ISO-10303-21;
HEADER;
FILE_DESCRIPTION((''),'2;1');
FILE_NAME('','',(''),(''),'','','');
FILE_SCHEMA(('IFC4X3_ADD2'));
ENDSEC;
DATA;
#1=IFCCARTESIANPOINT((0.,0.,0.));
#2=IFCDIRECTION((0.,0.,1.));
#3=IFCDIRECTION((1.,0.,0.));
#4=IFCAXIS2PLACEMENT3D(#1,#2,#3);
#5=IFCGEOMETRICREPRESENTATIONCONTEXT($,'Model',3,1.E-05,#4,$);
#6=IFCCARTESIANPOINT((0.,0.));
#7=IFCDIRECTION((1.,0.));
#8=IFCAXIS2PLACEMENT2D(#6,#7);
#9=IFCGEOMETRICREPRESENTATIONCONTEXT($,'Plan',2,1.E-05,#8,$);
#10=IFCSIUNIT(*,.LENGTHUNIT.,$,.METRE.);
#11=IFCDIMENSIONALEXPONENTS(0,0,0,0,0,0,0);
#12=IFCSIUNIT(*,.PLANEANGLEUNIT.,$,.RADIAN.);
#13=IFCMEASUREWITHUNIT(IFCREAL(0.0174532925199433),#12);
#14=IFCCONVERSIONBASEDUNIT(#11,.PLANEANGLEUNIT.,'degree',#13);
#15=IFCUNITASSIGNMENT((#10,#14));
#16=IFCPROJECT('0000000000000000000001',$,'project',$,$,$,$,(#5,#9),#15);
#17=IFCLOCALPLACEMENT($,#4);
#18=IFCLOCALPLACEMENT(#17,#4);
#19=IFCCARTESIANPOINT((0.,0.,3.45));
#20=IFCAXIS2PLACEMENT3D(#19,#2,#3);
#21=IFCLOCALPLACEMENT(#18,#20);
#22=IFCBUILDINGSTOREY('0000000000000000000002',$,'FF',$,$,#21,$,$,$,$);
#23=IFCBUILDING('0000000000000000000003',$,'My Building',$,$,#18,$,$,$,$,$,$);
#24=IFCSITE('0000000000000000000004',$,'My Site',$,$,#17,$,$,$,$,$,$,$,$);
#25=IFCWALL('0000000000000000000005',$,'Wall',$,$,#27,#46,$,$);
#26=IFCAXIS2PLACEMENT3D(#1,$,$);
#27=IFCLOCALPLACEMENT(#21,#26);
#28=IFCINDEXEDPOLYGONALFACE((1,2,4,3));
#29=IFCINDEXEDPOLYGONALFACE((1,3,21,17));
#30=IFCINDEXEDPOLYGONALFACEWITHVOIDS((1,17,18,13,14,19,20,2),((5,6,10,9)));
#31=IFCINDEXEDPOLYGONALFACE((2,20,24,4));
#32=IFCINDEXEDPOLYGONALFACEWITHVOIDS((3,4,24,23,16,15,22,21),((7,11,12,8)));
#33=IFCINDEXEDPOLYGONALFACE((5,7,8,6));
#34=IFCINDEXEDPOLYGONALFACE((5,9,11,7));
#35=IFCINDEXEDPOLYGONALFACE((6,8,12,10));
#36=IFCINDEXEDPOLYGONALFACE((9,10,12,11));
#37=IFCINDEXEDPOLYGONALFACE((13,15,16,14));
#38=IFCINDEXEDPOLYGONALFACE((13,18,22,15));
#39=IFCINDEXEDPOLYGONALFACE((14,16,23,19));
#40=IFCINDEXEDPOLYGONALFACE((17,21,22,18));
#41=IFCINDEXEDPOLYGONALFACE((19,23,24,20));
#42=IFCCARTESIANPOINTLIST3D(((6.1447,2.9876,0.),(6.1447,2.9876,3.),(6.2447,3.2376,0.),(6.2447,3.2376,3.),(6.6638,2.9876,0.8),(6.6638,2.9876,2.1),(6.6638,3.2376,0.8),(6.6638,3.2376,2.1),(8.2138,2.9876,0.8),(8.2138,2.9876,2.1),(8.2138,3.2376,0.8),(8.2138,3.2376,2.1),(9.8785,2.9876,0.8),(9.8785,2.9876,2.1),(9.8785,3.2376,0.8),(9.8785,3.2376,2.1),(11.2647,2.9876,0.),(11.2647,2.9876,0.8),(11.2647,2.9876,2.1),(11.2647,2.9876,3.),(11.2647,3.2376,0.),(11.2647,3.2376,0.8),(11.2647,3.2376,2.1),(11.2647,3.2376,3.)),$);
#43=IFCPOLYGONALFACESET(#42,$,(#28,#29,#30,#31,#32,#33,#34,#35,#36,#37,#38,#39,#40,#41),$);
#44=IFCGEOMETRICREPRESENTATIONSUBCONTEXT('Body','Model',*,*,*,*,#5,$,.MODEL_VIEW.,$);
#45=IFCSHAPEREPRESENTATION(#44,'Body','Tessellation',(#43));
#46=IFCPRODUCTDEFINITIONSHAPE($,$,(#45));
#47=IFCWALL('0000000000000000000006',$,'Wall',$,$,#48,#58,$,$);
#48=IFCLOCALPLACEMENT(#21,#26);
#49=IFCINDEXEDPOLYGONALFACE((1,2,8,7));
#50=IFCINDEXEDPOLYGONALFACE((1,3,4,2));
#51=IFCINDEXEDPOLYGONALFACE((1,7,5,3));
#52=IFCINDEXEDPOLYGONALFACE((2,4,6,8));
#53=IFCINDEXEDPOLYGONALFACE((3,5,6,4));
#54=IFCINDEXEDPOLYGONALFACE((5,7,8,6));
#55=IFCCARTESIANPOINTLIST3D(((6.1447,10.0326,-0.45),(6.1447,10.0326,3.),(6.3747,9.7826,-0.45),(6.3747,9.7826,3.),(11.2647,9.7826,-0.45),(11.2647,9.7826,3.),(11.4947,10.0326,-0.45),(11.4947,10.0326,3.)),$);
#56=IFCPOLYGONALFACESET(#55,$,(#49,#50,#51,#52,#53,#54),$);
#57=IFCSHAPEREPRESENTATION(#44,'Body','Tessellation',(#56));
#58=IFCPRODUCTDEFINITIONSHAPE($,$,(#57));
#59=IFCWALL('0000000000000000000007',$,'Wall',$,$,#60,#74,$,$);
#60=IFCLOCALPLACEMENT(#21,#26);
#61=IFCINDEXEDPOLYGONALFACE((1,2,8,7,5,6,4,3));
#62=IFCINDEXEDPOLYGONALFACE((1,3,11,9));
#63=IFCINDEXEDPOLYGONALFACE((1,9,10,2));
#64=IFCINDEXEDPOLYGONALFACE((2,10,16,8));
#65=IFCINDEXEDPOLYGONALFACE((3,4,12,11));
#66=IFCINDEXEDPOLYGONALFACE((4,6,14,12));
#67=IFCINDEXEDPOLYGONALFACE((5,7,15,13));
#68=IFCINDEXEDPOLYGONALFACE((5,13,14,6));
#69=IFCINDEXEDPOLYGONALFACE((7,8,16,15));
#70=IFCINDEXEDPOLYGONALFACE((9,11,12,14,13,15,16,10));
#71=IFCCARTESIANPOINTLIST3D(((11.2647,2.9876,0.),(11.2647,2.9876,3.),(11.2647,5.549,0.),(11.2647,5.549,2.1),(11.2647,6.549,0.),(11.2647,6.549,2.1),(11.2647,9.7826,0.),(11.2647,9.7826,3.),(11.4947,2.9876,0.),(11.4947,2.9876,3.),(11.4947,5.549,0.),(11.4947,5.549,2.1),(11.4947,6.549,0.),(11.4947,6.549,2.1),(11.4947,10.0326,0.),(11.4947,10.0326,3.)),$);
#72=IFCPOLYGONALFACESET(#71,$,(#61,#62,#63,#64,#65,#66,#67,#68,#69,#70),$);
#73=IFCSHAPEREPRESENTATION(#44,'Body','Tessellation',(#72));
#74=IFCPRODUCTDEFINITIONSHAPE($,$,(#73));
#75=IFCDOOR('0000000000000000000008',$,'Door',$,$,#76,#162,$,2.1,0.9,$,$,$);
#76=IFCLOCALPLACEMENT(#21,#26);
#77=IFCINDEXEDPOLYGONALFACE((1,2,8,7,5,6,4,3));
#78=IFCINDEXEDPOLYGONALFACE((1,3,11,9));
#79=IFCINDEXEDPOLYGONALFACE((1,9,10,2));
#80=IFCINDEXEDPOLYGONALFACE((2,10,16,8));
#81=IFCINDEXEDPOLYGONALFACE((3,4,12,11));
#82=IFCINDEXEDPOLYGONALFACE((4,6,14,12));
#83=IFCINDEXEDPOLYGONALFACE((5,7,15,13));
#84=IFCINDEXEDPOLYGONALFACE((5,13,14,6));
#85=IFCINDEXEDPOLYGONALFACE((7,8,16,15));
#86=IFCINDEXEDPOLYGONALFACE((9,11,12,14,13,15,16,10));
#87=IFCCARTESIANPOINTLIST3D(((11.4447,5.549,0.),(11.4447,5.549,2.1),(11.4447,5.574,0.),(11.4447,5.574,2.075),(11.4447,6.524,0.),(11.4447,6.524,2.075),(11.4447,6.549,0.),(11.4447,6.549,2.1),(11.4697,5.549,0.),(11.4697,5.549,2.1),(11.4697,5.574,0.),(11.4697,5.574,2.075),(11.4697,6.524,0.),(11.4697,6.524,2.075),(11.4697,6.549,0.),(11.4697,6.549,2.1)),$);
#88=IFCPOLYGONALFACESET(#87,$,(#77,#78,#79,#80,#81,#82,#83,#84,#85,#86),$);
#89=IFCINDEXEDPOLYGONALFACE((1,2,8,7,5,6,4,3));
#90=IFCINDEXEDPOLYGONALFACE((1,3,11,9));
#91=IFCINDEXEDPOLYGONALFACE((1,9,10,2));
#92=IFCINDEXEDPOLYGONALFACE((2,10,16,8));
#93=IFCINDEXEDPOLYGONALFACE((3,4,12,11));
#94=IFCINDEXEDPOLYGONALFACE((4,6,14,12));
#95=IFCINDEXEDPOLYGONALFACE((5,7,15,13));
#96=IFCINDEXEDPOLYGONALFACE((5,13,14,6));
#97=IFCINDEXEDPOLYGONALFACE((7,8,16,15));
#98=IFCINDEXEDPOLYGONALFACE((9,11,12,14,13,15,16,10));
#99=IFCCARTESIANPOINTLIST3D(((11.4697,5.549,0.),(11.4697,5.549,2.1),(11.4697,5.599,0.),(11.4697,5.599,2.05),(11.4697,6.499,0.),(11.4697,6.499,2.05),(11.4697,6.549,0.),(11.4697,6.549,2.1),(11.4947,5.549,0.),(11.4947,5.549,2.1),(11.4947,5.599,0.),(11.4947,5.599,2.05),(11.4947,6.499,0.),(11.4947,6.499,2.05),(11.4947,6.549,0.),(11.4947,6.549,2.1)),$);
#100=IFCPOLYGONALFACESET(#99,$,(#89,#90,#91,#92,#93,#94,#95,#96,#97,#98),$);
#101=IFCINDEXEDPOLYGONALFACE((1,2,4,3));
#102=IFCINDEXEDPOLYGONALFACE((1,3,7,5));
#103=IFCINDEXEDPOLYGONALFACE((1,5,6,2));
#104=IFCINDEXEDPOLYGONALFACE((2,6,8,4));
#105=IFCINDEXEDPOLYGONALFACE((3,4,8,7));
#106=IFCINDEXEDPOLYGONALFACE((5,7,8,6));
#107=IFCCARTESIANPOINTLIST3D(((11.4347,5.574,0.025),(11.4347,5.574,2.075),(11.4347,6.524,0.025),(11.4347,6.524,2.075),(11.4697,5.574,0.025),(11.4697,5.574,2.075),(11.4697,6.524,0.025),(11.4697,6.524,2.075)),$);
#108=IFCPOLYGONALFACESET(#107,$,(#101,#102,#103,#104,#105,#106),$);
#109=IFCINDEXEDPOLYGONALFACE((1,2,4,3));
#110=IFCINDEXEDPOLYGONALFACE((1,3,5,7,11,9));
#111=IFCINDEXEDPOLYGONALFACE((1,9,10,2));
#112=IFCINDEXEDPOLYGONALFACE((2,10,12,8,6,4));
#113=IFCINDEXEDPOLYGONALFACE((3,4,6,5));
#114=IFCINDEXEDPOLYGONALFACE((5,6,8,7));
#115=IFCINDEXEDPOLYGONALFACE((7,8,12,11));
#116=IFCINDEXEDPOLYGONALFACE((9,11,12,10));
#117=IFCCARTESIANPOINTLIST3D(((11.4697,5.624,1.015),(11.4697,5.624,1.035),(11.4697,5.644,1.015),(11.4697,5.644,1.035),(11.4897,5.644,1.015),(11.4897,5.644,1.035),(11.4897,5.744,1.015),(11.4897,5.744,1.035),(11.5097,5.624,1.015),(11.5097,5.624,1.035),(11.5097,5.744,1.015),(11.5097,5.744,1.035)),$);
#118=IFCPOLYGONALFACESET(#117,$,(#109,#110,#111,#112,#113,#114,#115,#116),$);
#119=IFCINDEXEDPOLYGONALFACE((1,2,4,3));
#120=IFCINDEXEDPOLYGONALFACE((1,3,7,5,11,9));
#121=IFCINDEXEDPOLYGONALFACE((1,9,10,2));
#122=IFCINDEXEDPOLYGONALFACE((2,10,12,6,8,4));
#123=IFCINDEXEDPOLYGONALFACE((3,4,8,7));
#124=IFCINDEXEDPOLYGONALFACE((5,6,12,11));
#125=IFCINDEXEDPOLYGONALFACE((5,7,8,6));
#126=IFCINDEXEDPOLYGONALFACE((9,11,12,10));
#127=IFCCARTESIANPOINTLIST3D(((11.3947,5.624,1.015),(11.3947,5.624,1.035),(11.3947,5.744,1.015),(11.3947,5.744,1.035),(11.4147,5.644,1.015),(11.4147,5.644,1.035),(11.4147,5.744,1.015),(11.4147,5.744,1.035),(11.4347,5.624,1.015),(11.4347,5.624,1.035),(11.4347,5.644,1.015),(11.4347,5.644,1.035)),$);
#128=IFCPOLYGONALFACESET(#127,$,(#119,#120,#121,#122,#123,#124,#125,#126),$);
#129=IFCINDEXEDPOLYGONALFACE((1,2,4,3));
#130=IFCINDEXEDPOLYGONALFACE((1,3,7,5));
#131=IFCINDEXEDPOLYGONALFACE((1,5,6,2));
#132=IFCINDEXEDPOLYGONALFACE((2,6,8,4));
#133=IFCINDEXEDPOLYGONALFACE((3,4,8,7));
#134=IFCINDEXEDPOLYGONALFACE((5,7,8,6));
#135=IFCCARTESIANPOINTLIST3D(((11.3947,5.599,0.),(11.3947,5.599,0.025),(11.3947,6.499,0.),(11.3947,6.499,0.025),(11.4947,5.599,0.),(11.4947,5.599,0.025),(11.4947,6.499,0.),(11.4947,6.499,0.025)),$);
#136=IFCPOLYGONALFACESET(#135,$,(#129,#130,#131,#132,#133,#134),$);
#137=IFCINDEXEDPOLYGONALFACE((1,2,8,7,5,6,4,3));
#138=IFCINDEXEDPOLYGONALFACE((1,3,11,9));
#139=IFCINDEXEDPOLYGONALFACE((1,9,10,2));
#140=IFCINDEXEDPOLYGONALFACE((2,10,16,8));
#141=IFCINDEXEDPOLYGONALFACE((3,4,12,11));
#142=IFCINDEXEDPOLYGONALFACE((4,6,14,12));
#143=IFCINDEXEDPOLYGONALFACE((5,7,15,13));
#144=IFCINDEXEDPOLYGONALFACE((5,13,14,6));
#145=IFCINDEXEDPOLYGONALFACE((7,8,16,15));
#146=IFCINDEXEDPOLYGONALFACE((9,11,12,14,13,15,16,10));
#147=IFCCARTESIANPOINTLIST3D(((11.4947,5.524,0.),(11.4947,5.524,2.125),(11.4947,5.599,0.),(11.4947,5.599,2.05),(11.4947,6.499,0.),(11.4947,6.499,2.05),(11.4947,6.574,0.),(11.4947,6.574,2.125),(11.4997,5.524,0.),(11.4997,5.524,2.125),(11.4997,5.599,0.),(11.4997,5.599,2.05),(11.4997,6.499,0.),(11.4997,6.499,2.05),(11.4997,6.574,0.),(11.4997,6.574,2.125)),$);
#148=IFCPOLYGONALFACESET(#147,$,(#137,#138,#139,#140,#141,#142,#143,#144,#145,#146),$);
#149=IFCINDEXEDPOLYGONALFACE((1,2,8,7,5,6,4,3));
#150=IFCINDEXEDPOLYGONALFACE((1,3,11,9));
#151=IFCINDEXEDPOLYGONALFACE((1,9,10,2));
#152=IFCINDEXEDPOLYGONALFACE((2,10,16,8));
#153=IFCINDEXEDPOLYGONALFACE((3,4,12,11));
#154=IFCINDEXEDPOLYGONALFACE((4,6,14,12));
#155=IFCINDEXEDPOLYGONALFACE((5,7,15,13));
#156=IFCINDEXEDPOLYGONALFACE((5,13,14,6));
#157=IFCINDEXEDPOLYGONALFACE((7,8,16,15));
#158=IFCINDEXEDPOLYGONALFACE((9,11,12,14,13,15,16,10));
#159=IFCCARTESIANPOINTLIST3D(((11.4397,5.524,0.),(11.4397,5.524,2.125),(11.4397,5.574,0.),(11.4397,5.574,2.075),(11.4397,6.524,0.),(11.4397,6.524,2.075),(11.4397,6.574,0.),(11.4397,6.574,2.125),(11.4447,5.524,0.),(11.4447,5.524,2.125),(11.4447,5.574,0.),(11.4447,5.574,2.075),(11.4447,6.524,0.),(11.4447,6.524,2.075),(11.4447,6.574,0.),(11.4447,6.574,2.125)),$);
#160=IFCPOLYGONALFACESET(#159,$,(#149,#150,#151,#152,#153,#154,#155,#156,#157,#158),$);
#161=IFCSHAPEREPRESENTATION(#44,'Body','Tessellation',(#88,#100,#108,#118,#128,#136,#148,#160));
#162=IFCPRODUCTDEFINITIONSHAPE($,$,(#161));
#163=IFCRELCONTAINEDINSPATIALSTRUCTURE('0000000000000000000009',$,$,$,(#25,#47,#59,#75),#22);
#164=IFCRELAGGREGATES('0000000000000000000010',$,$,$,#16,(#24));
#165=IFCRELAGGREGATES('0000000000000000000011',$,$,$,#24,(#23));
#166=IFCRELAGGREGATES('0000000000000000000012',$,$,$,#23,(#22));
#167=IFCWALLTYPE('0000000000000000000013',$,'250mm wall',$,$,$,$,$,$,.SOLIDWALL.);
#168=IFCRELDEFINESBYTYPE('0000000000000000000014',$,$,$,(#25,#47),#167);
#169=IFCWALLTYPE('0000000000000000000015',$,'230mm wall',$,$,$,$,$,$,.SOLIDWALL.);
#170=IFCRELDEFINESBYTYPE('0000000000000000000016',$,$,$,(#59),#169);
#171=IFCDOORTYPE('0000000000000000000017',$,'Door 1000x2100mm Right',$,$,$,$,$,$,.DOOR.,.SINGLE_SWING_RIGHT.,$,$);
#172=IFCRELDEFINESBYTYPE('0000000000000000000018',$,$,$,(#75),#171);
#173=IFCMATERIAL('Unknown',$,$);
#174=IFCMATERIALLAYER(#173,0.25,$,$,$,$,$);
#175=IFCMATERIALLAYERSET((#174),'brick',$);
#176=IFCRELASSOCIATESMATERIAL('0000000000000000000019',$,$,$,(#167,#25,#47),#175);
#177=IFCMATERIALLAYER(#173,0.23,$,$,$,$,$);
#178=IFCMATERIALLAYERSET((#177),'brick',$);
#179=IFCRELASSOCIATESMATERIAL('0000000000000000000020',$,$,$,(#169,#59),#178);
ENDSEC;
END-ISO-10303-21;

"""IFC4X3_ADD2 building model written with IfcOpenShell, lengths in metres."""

from ifc_helpers import new_model, entity, si_unit, converted_unit, frame, origin_with_axes, origin_2d_with_axis, place, context, subcontext, project, spatial, line, indexed_curve, outline, extrude, shape, source, transform, mapped, material, layer, layer_set, layer_usage, type_object, type_shapes, element, fill, save


model = new_model("IFC4X3_ADD2")

# Units and contexts
model_context = context("Model", 3, precision=1e-05, world=origin_with_axes())
plan_context = context("Plan", 2, precision=1e-05, world=origin_2d_with_axis())
body_context_1 = subcontext(model_context, "Body", "Model", "MODEL_VIEW")
body_context_2 = subcontext(plan_context, "Body", "Plan", "PLAN_VIEW")
ifc_project = project(units=[si_unit("LENGTHUNIT", "METRE"), converted_unit("PLANEANGLEUNIT", "degree", entity("IfcReal", 0.0174532925199433), si_unit("PLANEANGLEUNIT", "RADIAN"), dimensions=[0, 0, 0, 0, 0, 0, 0])], contexts=[model_context, plan_context])

# Site, building, storey
site_placement = place(None, origin_with_axes())
site = spatial("IfcSite", under=ifc_project, at=site_placement, Name="My Site")
building_placement = place(site_placement, origin_with_axes())
building = spatial("IfcBuilding", under=site, at=building_placement, Name="My Building")
storey_placement = place(building_placement, frame((0.0, 0.0, 3.45), z_axis=(0.0, 0.0, 1.0), x_axis=(1.0, 0.0, 0.0)))
storey = spatial("IfcBuildingStorey", under=building, at=storey_placement, Name="FF")

# Wall, openings
ifc_material = material(Name="Unknown")
ifc_layer_1 = layer(ifc_material, 0.25)
ifc_layer_set_1 = layer_set([ifc_layer_1], Name="brick")
ifc_layer_usage_1 = layer_usage(ifc_layer_set_1, "AXIS2", "POSITIVE", 0.0)
wall_type_1 = type_object("IfcWallType", Name="250mm wall", PredefinedType="SOLIDWALL", material=ifc_layer_set_1)
wall_1_placement = place(storey_placement, frame((6.2447, 2.9876, 0.0), z_axis=(0.0, 0.0, 1.0), x_axis=(1.0, 0.0, 0.0)))
wall_1 = element("IfcWall", 1, at=wall_1_placement, inside=storey, type_object=wall_type_1, material=ifc_layer_usage_1, Name="Wall", context=body_context_1, shape_type="SweptSolid", body=[
    extrude(outline(indexed_curve([(-0.1, 0.0), (0.0, 0.25), (5.02, 0.25), (5.02, 0.0)], segments=[line(1, 2, 3, 4, 1)])), origin_with_axes(), (0.0, 0.0, 1.0), 3.0),
])
shared_shape_1 = source(origin_with_axes(), body_context_1, "Body", "SweptSolid", [
    extrude(outline(indexed_curve([(0.0, 0.0), (1.55, 0.0), (1.55, 1.3), (0.0, 1.3)], segments=[line(1, 2, 3, 4, 1)])), frame((-0.775, -0.6, 0.0), z_axis=(0.0, -1.0, 0.0), x_axis=(1.0, 0.0, 0.0)), (0.0, 0.0, -1.0), 1.2),
])
opening_1_placement = place(wall_1_placement, frame((1.1942, 0.0, 0.8), z_axis=(0.0, 0.0, 1.0), x_axis=(1.0, 0.0, 0.0)))
element("IfcOpeningElement", 2, at=opening_1_placement, cuts=wall_1, PredefinedType="OPENING", context=body_context_1, shape_type="MappedRepresentation", body=[
    mapped(shared_shape_1, transform((0.0, 0.0, 0.0), x_axis=(1.0, 0.0, 0.0), y_axis=(0.0, 1.0, 0.0), z_axis=(0.0, 0.0, 1.0), scale=1.0)),
])
opening_2_placement = place(wall_1_placement, frame((4.4089, 0.0, 0.8), z_axis=(0.0, 0.0, 1.0), x_axis=(1.0, 0.0, 0.0)))
element("IfcOpeningElement", 3, at=opening_2_placement, cuts=wall_1, PredefinedType="OPENING", context=body_context_1, shape_type="MappedRepresentation", body=[
    mapped(shared_shape_1, transform((0.0, 0.0, 0.0), x_axis=(1.0, 0.0, 0.0), y_axis=(0.0, 1.0, 0.0), z_axis=(0.0, 0.0, 1.0), scale=1.0)),
])

# Wall
ifc_layer_usage_2 = layer_usage(ifc_layer_set_1, "AXIS2", "POSITIVE", 0.0)
wall_2_placement = place(storey_placement, frame((6.3747, 9.7826, -0.45), z_axis=(0.0, 0.0, 1.0), x_axis=(1.0, 0.0, 0.0)))
element("IfcWall", 4, at=wall_2_placement, inside=storey, type_object=wall_type_1, material=ifc_layer_usage_2, Name="Wall", context=body_context_1, shape_type="SweptSolid", body=[
    extrude(outline(indexed_curve([(0.0, 0.0), (-0.23, 0.25), (5.12, 0.25), (4.89, 0.0)], segments=[line(1, 2, 3, 4, 1)])), origin_with_axes(), (0.0, 0.0, 1.0), 3.45),
])

# Wall, opening, door
ifc_layer_2 = layer(ifc_material, 0.23)
ifc_layer_set_2 = layer_set([ifc_layer_2], Name="brick")
ifc_layer_usage_3 = layer_usage(ifc_layer_set_2, "AXIS2", "POSITIVE", 0.0)
wall_type_2 = type_object("IfcWallType", Name="230mm wall", PredefinedType="SOLIDWALL", material=ifc_layer_set_2)
wall_3_placement = place(storey_placement, frame((11.4947, 2.9876, 0.0), z_axis=(0.0, 0.0, 1.0), x_axis=(0.0, 1.0, 0.0)))
wall_3 = element("IfcWall", 5, at=wall_3_placement, inside=storey, type_object=wall_type_2, material=ifc_layer_usage_3, Name="Wall", context=body_context_1, shape_type="SweptSolid", body=[
    extrude(outline(indexed_curve([(0.0, 0.0), (0.0, 0.23), (6.795, 0.23), (7.045, 0.0)], segments=[line(1, 2, 3, 4, 1)])), origin_with_axes(), (0.0, 0.0, 1.0), 3.0),
])
shared_shape_2 = source(origin_with_axes(), body_context_1, "Body", "SolidModel", [
    extrude(outline(indexed_curve([(0.0, 0.0), (1.0, 0.0), (1.0, 2.1), (0.0, 2.1)], segments=[line(1, 2, 3, 4, 1)])), frame((0.0, -0.6, 0.0), z_axis=(0.0, -1.0, 0.0), x_axis=(1.0, 0.0, 0.0)), (0.0, 0.0, -1.0), 1.2),
])
opening_3_placement = place(wall_3_placement, frame((2.5614, 0.0, 0.0), z_axis=(0.0, 0.0, 1.0), x_axis=(1.0, 0.0, 0.0)))
opening_3 = element("IfcOpeningElement", 6, at=opening_3_placement, cuts=wall_3, PredefinedType="OPENING", context=body_context_1, shape_type="MappedRepresentation", body=[
    mapped(shared_shape_2, transform((0.0, 0.0, 0.0), x_axis=(1.0, 0.0, 0.0), y_axis=(0.0, 1.0, 0.0), z_axis=(0.0, 0.0, 1.0), scale=1.0)),
])
door_type_1 = type_object("IfcDoorType", Name="Door 1000x2100mm Right", OperationType="SINGLE_SWING_RIGHT", PredefinedType="DOOR")
shared_shape_3 = source(origin_with_axes(), body_context_1, "Body", "SweptSolid", [
    extrude(outline(indexed_curve([(0.0, 0.0), (0.0, 2.1), (1.0, 2.1), (1.0, 0.0), (0.975, 0.0), (0.975, 2.075), (0.025, 2.075), (0.025, 0.0)], segments=[line(1, 2, 3, 4, 5, 6, 7, 8, 1)])), frame((0.0, 0.025, 0.0), z_axis=(0.0, -1.0, 0.0), x_axis=(1.0, 0.0, 0.0)), (0.0, 0.0, -1.0), 0.025),
    extrude(outline(indexed_curve([(0.0, 0.0), (0.0, 2.1), (1.0, 2.1), (1.0, 0.0), (0.95, 0.0), (0.95, 2.05), (0.05, 2.05), (0.05, 0.0)], segments=[line(1, 2, 3, 4, 5, 6, 7, 8, 1)])), frame((0.0, 0.0, 0.0), z_axis=(0.0, -1.0, 0.0), x_axis=(1.0, 0.0, 0.0)), (0.0, 0.0, -1.0), 0.025),
    extrude(outline(indexed_curve([(0.0, 0.0), (0.95, 0.0), (0.95, 0.035), (0.0, 0.035)], segments=[line(1, 2, 3, 4, 1)])), frame((0.025, 0.025, 0.025), z_axis=(0.0, 0.0, 1.0), x_axis=(1.0, 0.0, 0.0)), (0.0, 0.0, 1.0), 2.05),
    extrude(outline(indexed_curve([(0.0, 0.0), (0.0, -0.04), (0.12, -0.04), (0.12, -0.02), (0.02, -0.02), (0.02, 0.0)], segments=[line(1, 2, 3, 4, 5, 6, 1)])), frame((0.075, 0.025, 1.015), z_axis=(0.0, 0.0, 1.0), x_axis=(1.0, 0.0, 0.0)), (0.0, 0.0, 1.0), 0.02),
    extrude(outline(indexed_curve([(0.0, 0.0), (0.0, 0.04), (0.12, 0.04), (0.12, 0.02), (0.02, 0.02), (0.02, 0.0)], segments=[line(1, 2, 3, 4, 5, 6, 1)])), frame((0.075, 0.06, 1.015), z_axis=(0.0, 0.0, 1.0), x_axis=(1.0, 0.0, 0.0)), (0.0, 0.0, 1.0), 0.02),
    extrude(outline(indexed_curve([(0.0, 0.0), (0.9, 0.0), (0.9, 0.1), (0.0, 0.1)], segments=[line(1, 2, 3, 4, 1)])), frame((0.05, 0.0, 0.0), z_axis=(0.0, 0.0, 1.0), x_axis=(1.0, 0.0, 0.0)), (0.0, 0.0, 1.0), 0.025),
    extrude(outline(indexed_curve([(0.0, 0.0), (0.0, 2.125), (1.05, 2.125), (1.05, 0.0), (0.975, 0.0), (0.975, 2.05), (0.075, 2.05), (0.075, 0.0)], segments=[line(1, 2, 3, 4, 5, 6, 7, 8, 1)])), frame((-0.025, -0.005, 0.0), z_axis=(0.0, -1.0, 0.0), x_axis=(1.0, 0.0, 0.0)), (0.0, 0.0, -1.0), 0.005),
    extrude(outline(indexed_curve([(0.0, 0.0), (0.0, 2.125), (1.05, 2.125), (1.05, 0.0), (1.0, 0.0), (1.0, 2.075), (0.05, 2.075), (0.05, 0.0)], segments=[line(1, 2, 3, 4, 5, 6, 7, 8, 1)])), frame((-0.025, 0.05, 0.0), z_axis=(0.0, -1.0, 0.0), x_axis=(1.0, 0.0, 0.0)), (0.0, 0.0, -1.0), 0.005),
])
shared_shape_4 = source(origin_with_axes(), body_context_2, "Body", "Curve2D", [
    entity("IfcIndexedPolyCurve", entity("IfcCartesianPointList2D", [[0.0, 0.0], [0.0, 0.05], [0.025, 0.05], [0.025, 0.025], [0.05, 0.025], [0.05, 0.0]]), [entity("IfcLineIndex", [1, 2, 3, 4, 5, 6, 1])]),
    entity("IfcIndexedPolyCurve", entity("IfcCartesianPointList2D", [[1.0, 0.0], [1.0, 0.05], [0.975, 0.05], [0.975, 0.025], [0.95, 0.025], [0.95, 0.0]]), [entity("IfcLineIndex", [1, 2, 3, 4, 5, 6, 1])]),
    entity("IfcTrimmedCurve", entity("IfcEllipse", entity("IfcAxis2Placement2D", entity("IfcCartesianPoint", [0.94, 0.05]), entity("IfcDirection", [1.0, 0.0])), 0.915, 0.95), [entity("IfcCartesianPoint", [0.94, 1.0])], [entity("IfcCartesianPoint", [0.025, 0.05])], True, "CARTESIAN"),
    entity("IfcIndexedPolyCurve", entity("IfcCartesianPointList2D", [[0.975, 0.05], [0.94, 0.05], [0.94, 1.0], [0.975, 1.0]]), [entity("IfcLineIndex", [1, 2, 3, 4, 1])]),
])
type_shapes(door_type_1, [shared_shape_3, shared_shape_4])
door_1_placement = place(opening_3_placement, frame((0.0, 0.0, 0.0), z_axis=(0.0, 0.0, 1.0), x_axis=(1.0, 0.0, 0.0)))
door_1 = element("IfcDoor", 7, at=door_1_placement, inside=storey, type_object=door_type_1, Name="Door", OverallHeight=2.1, OverallWidth=0.9, shapes=[
    shape(body_context_1, "Body", "MappedRepresentation", [mapped(shared_shape_3, transform((0.0, 0.0, 0.0), x_axis=(1.0, 0.0, 0.0), y_axis=(0.0, 1.0, 0.0), z_axis=(0.0, 0.0, 1.0), scale=1.0))]),
    shape(body_context_2, "Body", "MappedRepresentation", [mapped(shared_shape_4, transform((0.0, 0.0, 0.0), x_axis=(1.0, 0.0, 0.0), y_axis=(0.0, 1.0, 0.0), z_axis=(0.0, 0.0, 1.0), scale=1.0))]),
])
fill(opening_3, door_1)

save(model, "model.ifc")
